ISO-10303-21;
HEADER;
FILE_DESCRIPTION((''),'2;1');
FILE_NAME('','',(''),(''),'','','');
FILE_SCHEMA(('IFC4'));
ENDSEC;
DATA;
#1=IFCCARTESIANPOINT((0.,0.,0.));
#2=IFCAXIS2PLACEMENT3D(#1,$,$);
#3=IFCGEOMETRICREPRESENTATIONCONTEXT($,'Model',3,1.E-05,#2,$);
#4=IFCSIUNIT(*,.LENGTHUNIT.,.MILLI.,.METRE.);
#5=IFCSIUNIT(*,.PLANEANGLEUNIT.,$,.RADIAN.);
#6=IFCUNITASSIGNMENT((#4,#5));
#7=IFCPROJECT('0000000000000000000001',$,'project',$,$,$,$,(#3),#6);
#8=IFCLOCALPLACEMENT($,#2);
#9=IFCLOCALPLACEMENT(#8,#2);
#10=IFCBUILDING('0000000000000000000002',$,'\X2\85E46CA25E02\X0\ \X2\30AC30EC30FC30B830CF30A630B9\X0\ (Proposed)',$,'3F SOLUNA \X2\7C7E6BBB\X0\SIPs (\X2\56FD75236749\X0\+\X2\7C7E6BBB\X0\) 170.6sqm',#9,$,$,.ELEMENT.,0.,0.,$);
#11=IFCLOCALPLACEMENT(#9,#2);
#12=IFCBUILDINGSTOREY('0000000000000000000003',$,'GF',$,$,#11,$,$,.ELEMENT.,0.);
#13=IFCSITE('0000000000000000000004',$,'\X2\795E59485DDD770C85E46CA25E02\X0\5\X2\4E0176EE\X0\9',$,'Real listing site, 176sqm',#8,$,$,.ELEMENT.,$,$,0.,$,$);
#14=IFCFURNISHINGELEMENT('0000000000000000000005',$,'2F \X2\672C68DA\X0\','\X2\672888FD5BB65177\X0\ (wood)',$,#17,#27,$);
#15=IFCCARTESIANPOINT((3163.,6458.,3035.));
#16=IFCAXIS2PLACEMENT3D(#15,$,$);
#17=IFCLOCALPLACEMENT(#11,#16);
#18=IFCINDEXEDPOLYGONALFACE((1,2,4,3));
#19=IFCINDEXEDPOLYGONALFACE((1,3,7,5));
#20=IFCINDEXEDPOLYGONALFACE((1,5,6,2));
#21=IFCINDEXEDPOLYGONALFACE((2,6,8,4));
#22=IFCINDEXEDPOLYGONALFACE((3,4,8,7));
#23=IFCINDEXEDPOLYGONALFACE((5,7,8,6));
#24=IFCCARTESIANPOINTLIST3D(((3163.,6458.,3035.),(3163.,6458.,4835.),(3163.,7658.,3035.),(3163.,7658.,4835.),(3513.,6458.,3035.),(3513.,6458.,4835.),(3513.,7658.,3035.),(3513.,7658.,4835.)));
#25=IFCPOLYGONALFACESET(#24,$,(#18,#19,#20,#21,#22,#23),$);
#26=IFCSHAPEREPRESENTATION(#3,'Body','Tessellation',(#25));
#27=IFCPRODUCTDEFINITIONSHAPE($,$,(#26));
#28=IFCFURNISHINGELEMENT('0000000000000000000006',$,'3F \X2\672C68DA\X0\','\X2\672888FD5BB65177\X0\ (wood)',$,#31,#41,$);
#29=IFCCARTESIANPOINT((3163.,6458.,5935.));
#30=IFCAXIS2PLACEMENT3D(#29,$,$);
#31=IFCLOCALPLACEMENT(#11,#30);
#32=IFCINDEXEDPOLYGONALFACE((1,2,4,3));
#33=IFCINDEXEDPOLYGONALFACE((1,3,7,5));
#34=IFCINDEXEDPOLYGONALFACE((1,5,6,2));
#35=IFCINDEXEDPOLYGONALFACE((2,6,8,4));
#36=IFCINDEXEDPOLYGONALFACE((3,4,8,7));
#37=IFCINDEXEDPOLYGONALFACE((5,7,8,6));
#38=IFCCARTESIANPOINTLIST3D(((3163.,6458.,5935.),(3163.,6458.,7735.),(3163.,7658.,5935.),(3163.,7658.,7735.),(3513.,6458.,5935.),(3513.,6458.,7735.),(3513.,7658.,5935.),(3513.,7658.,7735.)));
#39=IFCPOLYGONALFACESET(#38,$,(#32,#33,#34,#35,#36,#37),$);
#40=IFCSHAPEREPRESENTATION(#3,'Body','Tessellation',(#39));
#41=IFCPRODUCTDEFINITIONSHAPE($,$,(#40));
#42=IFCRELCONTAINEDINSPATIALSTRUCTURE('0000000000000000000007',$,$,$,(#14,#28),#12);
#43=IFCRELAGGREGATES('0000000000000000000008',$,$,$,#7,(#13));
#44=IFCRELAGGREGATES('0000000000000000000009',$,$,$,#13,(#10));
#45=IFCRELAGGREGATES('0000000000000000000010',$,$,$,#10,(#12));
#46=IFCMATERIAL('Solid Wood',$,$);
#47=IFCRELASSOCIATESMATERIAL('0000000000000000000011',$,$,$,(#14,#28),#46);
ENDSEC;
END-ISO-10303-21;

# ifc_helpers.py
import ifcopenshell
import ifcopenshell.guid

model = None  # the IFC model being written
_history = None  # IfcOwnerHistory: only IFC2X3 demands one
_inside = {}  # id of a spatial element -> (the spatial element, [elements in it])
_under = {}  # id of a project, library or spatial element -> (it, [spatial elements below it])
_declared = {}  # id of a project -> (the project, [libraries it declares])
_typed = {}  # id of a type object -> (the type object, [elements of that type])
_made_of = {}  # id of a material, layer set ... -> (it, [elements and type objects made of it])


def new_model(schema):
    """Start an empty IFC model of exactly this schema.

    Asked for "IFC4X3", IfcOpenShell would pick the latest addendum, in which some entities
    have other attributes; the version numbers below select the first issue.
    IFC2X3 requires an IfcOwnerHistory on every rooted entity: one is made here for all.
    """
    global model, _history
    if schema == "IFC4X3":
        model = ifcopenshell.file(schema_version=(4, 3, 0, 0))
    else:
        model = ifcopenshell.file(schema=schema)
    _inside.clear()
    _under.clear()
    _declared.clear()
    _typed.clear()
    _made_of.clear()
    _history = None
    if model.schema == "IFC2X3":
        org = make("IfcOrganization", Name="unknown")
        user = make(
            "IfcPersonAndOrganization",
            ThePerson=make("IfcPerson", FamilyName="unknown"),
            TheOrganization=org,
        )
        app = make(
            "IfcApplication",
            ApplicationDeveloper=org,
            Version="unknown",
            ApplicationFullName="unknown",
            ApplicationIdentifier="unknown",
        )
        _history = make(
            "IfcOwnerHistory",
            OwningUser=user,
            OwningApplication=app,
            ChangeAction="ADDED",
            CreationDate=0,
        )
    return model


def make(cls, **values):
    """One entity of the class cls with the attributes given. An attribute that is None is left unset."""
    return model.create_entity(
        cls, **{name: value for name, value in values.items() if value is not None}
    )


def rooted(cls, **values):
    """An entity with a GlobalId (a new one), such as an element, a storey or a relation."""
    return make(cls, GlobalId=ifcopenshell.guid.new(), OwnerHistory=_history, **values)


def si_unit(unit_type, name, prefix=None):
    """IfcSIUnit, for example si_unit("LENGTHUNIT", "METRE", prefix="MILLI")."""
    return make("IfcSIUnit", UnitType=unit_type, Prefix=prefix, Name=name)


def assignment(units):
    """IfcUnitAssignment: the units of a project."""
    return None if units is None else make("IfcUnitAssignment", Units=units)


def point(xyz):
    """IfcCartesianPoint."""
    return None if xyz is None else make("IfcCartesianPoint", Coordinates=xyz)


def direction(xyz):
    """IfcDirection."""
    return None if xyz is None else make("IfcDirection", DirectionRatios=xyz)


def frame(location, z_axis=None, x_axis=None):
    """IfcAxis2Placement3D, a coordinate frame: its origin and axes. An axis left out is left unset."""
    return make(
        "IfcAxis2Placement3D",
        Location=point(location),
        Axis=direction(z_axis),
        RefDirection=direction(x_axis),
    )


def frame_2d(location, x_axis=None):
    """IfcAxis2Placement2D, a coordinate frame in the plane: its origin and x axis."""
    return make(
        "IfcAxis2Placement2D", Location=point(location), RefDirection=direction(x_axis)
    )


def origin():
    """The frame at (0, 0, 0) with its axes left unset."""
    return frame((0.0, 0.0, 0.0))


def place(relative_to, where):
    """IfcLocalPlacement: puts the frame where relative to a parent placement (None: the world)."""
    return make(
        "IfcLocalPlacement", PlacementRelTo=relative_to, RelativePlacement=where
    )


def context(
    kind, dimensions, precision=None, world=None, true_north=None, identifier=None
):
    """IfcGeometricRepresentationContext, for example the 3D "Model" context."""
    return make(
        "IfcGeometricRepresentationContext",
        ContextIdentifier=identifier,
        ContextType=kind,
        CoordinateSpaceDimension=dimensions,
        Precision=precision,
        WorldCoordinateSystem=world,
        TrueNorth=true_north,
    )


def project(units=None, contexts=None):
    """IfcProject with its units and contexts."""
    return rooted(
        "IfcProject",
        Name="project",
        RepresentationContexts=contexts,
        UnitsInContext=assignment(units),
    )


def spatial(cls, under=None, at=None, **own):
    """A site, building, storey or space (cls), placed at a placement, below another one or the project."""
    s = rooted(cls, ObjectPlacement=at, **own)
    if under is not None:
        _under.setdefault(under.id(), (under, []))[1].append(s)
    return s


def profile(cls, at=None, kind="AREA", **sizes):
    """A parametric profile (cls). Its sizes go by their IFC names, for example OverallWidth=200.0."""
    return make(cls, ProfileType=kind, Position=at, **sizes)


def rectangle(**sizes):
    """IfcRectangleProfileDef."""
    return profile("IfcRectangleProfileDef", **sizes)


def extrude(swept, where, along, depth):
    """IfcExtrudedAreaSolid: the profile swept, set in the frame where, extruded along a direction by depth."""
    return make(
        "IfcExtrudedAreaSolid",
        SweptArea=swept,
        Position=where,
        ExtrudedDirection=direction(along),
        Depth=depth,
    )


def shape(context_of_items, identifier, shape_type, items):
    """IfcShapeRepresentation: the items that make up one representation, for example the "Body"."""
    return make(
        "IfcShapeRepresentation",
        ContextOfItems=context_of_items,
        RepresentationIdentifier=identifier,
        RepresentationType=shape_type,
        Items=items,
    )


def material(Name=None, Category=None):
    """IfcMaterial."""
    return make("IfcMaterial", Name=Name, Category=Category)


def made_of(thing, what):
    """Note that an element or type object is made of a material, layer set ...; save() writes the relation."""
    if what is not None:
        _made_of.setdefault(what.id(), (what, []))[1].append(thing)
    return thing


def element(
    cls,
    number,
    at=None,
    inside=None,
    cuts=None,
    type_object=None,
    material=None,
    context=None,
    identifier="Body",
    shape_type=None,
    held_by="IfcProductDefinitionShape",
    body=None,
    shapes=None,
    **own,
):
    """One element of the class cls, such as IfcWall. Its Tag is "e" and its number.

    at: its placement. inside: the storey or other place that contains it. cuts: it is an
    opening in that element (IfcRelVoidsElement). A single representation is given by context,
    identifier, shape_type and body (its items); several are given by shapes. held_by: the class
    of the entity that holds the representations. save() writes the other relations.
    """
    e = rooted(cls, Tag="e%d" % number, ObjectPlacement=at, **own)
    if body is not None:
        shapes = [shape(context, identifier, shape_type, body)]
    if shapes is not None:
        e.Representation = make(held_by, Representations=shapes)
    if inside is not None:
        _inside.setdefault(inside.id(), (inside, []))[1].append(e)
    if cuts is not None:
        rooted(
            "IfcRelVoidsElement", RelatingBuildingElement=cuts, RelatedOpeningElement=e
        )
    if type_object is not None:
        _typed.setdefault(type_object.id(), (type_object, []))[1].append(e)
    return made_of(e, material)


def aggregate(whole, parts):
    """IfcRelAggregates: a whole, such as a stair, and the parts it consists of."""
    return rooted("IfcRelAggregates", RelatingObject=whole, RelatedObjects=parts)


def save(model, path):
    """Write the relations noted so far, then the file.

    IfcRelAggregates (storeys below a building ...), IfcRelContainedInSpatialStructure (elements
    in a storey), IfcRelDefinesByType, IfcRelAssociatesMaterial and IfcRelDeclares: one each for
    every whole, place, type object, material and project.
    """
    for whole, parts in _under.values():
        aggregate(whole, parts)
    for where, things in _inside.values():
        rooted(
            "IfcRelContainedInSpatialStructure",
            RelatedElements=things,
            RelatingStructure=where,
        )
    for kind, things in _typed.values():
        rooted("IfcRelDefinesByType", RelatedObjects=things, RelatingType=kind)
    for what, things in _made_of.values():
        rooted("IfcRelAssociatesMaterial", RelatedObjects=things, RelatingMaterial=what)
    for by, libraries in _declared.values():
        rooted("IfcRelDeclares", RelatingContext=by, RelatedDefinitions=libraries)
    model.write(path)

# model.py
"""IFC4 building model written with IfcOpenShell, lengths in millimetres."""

from ifc_helpers import new_model, si_unit, frame, frame_2d, origin, place, context, project, spatial, rectangle, extrude, material, element, save


model = new_model("IFC4")

# Units and contexts
model_context = context("Model", 3, precision=1e-05, world=origin())
ifc_project = project(units=[si_unit("LENGTHUNIT", "METRE", prefix="MILLI"), si_unit("PLANEANGLEUNIT", "RADIAN")], contexts=[model_context])

# Site, building, storey
site_placement = place(None, origin())
site = spatial("IfcSite", under=ifc_project, at=site_placement, Name="神奈川県藤沢市5丁目9", ObjectType="Real listing site, 176sqm", CompositionType="ELEMENT", RefElevation=0.0)
building_placement = place(site_placement, origin())
building = spatial("IfcBuilding", under=site, at=building_placement, Name="藤沢市 ガレージハウス (Proposed)", ObjectType="3F SOLUNA 籾殻SIPs (国産杉+籾殻) 170.6sqm", CompositionType="ELEMENT", ElevationOfRefHeight=0.0, ElevationOfTerrain=0.0)
storey_placement = place(building_placement, origin())
storey = spatial("IfcBuildingStorey", under=building, at=storey_placement, Name="GF", CompositionType="ELEMENT", Elevation=0.0)

# Shared definitions
ifc_material_1 = material(Name="Solid Wood")

# Furnishing elements
furnishing_1_placement = place(storey_placement, frame((3163.0, 6458.0, 3035.0)))
element("IfcFurnishingElement", 1, at=furnishing_1_placement, inside=storey, material=ifc_material_1, Name="2F 本棚", Description="木製家具 (wood)", context=model_context, shape_type="SweptSolid", body=[
    extrude(rectangle(XDim=350.0, YDim=1200.0, at=frame_2d((175.0, 600.0))), frame((3163.0, 6458.0, 3035.0)), (0.0, 0.0, 1.0), 1800.0),
])
furnishing_2_placement = place(storey_placement, frame((3163.0, 6458.0, 5935.0)))
element("IfcFurnishingElement", 2, at=furnishing_2_placement, inside=storey, material=ifc_material_1, Name="3F 本棚", Description="木製家具 (wood)", context=model_context, shape_type="SweptSolid", body=[
    extrude(rectangle(XDim=350.0, YDim=1200.0, at=frame_2d((175.0, 600.0))), frame((3163.0, 6458.0, 5935.0)), (0.0, 0.0, 1.0), 1800.0),
])

save(model, "model.ifc")
